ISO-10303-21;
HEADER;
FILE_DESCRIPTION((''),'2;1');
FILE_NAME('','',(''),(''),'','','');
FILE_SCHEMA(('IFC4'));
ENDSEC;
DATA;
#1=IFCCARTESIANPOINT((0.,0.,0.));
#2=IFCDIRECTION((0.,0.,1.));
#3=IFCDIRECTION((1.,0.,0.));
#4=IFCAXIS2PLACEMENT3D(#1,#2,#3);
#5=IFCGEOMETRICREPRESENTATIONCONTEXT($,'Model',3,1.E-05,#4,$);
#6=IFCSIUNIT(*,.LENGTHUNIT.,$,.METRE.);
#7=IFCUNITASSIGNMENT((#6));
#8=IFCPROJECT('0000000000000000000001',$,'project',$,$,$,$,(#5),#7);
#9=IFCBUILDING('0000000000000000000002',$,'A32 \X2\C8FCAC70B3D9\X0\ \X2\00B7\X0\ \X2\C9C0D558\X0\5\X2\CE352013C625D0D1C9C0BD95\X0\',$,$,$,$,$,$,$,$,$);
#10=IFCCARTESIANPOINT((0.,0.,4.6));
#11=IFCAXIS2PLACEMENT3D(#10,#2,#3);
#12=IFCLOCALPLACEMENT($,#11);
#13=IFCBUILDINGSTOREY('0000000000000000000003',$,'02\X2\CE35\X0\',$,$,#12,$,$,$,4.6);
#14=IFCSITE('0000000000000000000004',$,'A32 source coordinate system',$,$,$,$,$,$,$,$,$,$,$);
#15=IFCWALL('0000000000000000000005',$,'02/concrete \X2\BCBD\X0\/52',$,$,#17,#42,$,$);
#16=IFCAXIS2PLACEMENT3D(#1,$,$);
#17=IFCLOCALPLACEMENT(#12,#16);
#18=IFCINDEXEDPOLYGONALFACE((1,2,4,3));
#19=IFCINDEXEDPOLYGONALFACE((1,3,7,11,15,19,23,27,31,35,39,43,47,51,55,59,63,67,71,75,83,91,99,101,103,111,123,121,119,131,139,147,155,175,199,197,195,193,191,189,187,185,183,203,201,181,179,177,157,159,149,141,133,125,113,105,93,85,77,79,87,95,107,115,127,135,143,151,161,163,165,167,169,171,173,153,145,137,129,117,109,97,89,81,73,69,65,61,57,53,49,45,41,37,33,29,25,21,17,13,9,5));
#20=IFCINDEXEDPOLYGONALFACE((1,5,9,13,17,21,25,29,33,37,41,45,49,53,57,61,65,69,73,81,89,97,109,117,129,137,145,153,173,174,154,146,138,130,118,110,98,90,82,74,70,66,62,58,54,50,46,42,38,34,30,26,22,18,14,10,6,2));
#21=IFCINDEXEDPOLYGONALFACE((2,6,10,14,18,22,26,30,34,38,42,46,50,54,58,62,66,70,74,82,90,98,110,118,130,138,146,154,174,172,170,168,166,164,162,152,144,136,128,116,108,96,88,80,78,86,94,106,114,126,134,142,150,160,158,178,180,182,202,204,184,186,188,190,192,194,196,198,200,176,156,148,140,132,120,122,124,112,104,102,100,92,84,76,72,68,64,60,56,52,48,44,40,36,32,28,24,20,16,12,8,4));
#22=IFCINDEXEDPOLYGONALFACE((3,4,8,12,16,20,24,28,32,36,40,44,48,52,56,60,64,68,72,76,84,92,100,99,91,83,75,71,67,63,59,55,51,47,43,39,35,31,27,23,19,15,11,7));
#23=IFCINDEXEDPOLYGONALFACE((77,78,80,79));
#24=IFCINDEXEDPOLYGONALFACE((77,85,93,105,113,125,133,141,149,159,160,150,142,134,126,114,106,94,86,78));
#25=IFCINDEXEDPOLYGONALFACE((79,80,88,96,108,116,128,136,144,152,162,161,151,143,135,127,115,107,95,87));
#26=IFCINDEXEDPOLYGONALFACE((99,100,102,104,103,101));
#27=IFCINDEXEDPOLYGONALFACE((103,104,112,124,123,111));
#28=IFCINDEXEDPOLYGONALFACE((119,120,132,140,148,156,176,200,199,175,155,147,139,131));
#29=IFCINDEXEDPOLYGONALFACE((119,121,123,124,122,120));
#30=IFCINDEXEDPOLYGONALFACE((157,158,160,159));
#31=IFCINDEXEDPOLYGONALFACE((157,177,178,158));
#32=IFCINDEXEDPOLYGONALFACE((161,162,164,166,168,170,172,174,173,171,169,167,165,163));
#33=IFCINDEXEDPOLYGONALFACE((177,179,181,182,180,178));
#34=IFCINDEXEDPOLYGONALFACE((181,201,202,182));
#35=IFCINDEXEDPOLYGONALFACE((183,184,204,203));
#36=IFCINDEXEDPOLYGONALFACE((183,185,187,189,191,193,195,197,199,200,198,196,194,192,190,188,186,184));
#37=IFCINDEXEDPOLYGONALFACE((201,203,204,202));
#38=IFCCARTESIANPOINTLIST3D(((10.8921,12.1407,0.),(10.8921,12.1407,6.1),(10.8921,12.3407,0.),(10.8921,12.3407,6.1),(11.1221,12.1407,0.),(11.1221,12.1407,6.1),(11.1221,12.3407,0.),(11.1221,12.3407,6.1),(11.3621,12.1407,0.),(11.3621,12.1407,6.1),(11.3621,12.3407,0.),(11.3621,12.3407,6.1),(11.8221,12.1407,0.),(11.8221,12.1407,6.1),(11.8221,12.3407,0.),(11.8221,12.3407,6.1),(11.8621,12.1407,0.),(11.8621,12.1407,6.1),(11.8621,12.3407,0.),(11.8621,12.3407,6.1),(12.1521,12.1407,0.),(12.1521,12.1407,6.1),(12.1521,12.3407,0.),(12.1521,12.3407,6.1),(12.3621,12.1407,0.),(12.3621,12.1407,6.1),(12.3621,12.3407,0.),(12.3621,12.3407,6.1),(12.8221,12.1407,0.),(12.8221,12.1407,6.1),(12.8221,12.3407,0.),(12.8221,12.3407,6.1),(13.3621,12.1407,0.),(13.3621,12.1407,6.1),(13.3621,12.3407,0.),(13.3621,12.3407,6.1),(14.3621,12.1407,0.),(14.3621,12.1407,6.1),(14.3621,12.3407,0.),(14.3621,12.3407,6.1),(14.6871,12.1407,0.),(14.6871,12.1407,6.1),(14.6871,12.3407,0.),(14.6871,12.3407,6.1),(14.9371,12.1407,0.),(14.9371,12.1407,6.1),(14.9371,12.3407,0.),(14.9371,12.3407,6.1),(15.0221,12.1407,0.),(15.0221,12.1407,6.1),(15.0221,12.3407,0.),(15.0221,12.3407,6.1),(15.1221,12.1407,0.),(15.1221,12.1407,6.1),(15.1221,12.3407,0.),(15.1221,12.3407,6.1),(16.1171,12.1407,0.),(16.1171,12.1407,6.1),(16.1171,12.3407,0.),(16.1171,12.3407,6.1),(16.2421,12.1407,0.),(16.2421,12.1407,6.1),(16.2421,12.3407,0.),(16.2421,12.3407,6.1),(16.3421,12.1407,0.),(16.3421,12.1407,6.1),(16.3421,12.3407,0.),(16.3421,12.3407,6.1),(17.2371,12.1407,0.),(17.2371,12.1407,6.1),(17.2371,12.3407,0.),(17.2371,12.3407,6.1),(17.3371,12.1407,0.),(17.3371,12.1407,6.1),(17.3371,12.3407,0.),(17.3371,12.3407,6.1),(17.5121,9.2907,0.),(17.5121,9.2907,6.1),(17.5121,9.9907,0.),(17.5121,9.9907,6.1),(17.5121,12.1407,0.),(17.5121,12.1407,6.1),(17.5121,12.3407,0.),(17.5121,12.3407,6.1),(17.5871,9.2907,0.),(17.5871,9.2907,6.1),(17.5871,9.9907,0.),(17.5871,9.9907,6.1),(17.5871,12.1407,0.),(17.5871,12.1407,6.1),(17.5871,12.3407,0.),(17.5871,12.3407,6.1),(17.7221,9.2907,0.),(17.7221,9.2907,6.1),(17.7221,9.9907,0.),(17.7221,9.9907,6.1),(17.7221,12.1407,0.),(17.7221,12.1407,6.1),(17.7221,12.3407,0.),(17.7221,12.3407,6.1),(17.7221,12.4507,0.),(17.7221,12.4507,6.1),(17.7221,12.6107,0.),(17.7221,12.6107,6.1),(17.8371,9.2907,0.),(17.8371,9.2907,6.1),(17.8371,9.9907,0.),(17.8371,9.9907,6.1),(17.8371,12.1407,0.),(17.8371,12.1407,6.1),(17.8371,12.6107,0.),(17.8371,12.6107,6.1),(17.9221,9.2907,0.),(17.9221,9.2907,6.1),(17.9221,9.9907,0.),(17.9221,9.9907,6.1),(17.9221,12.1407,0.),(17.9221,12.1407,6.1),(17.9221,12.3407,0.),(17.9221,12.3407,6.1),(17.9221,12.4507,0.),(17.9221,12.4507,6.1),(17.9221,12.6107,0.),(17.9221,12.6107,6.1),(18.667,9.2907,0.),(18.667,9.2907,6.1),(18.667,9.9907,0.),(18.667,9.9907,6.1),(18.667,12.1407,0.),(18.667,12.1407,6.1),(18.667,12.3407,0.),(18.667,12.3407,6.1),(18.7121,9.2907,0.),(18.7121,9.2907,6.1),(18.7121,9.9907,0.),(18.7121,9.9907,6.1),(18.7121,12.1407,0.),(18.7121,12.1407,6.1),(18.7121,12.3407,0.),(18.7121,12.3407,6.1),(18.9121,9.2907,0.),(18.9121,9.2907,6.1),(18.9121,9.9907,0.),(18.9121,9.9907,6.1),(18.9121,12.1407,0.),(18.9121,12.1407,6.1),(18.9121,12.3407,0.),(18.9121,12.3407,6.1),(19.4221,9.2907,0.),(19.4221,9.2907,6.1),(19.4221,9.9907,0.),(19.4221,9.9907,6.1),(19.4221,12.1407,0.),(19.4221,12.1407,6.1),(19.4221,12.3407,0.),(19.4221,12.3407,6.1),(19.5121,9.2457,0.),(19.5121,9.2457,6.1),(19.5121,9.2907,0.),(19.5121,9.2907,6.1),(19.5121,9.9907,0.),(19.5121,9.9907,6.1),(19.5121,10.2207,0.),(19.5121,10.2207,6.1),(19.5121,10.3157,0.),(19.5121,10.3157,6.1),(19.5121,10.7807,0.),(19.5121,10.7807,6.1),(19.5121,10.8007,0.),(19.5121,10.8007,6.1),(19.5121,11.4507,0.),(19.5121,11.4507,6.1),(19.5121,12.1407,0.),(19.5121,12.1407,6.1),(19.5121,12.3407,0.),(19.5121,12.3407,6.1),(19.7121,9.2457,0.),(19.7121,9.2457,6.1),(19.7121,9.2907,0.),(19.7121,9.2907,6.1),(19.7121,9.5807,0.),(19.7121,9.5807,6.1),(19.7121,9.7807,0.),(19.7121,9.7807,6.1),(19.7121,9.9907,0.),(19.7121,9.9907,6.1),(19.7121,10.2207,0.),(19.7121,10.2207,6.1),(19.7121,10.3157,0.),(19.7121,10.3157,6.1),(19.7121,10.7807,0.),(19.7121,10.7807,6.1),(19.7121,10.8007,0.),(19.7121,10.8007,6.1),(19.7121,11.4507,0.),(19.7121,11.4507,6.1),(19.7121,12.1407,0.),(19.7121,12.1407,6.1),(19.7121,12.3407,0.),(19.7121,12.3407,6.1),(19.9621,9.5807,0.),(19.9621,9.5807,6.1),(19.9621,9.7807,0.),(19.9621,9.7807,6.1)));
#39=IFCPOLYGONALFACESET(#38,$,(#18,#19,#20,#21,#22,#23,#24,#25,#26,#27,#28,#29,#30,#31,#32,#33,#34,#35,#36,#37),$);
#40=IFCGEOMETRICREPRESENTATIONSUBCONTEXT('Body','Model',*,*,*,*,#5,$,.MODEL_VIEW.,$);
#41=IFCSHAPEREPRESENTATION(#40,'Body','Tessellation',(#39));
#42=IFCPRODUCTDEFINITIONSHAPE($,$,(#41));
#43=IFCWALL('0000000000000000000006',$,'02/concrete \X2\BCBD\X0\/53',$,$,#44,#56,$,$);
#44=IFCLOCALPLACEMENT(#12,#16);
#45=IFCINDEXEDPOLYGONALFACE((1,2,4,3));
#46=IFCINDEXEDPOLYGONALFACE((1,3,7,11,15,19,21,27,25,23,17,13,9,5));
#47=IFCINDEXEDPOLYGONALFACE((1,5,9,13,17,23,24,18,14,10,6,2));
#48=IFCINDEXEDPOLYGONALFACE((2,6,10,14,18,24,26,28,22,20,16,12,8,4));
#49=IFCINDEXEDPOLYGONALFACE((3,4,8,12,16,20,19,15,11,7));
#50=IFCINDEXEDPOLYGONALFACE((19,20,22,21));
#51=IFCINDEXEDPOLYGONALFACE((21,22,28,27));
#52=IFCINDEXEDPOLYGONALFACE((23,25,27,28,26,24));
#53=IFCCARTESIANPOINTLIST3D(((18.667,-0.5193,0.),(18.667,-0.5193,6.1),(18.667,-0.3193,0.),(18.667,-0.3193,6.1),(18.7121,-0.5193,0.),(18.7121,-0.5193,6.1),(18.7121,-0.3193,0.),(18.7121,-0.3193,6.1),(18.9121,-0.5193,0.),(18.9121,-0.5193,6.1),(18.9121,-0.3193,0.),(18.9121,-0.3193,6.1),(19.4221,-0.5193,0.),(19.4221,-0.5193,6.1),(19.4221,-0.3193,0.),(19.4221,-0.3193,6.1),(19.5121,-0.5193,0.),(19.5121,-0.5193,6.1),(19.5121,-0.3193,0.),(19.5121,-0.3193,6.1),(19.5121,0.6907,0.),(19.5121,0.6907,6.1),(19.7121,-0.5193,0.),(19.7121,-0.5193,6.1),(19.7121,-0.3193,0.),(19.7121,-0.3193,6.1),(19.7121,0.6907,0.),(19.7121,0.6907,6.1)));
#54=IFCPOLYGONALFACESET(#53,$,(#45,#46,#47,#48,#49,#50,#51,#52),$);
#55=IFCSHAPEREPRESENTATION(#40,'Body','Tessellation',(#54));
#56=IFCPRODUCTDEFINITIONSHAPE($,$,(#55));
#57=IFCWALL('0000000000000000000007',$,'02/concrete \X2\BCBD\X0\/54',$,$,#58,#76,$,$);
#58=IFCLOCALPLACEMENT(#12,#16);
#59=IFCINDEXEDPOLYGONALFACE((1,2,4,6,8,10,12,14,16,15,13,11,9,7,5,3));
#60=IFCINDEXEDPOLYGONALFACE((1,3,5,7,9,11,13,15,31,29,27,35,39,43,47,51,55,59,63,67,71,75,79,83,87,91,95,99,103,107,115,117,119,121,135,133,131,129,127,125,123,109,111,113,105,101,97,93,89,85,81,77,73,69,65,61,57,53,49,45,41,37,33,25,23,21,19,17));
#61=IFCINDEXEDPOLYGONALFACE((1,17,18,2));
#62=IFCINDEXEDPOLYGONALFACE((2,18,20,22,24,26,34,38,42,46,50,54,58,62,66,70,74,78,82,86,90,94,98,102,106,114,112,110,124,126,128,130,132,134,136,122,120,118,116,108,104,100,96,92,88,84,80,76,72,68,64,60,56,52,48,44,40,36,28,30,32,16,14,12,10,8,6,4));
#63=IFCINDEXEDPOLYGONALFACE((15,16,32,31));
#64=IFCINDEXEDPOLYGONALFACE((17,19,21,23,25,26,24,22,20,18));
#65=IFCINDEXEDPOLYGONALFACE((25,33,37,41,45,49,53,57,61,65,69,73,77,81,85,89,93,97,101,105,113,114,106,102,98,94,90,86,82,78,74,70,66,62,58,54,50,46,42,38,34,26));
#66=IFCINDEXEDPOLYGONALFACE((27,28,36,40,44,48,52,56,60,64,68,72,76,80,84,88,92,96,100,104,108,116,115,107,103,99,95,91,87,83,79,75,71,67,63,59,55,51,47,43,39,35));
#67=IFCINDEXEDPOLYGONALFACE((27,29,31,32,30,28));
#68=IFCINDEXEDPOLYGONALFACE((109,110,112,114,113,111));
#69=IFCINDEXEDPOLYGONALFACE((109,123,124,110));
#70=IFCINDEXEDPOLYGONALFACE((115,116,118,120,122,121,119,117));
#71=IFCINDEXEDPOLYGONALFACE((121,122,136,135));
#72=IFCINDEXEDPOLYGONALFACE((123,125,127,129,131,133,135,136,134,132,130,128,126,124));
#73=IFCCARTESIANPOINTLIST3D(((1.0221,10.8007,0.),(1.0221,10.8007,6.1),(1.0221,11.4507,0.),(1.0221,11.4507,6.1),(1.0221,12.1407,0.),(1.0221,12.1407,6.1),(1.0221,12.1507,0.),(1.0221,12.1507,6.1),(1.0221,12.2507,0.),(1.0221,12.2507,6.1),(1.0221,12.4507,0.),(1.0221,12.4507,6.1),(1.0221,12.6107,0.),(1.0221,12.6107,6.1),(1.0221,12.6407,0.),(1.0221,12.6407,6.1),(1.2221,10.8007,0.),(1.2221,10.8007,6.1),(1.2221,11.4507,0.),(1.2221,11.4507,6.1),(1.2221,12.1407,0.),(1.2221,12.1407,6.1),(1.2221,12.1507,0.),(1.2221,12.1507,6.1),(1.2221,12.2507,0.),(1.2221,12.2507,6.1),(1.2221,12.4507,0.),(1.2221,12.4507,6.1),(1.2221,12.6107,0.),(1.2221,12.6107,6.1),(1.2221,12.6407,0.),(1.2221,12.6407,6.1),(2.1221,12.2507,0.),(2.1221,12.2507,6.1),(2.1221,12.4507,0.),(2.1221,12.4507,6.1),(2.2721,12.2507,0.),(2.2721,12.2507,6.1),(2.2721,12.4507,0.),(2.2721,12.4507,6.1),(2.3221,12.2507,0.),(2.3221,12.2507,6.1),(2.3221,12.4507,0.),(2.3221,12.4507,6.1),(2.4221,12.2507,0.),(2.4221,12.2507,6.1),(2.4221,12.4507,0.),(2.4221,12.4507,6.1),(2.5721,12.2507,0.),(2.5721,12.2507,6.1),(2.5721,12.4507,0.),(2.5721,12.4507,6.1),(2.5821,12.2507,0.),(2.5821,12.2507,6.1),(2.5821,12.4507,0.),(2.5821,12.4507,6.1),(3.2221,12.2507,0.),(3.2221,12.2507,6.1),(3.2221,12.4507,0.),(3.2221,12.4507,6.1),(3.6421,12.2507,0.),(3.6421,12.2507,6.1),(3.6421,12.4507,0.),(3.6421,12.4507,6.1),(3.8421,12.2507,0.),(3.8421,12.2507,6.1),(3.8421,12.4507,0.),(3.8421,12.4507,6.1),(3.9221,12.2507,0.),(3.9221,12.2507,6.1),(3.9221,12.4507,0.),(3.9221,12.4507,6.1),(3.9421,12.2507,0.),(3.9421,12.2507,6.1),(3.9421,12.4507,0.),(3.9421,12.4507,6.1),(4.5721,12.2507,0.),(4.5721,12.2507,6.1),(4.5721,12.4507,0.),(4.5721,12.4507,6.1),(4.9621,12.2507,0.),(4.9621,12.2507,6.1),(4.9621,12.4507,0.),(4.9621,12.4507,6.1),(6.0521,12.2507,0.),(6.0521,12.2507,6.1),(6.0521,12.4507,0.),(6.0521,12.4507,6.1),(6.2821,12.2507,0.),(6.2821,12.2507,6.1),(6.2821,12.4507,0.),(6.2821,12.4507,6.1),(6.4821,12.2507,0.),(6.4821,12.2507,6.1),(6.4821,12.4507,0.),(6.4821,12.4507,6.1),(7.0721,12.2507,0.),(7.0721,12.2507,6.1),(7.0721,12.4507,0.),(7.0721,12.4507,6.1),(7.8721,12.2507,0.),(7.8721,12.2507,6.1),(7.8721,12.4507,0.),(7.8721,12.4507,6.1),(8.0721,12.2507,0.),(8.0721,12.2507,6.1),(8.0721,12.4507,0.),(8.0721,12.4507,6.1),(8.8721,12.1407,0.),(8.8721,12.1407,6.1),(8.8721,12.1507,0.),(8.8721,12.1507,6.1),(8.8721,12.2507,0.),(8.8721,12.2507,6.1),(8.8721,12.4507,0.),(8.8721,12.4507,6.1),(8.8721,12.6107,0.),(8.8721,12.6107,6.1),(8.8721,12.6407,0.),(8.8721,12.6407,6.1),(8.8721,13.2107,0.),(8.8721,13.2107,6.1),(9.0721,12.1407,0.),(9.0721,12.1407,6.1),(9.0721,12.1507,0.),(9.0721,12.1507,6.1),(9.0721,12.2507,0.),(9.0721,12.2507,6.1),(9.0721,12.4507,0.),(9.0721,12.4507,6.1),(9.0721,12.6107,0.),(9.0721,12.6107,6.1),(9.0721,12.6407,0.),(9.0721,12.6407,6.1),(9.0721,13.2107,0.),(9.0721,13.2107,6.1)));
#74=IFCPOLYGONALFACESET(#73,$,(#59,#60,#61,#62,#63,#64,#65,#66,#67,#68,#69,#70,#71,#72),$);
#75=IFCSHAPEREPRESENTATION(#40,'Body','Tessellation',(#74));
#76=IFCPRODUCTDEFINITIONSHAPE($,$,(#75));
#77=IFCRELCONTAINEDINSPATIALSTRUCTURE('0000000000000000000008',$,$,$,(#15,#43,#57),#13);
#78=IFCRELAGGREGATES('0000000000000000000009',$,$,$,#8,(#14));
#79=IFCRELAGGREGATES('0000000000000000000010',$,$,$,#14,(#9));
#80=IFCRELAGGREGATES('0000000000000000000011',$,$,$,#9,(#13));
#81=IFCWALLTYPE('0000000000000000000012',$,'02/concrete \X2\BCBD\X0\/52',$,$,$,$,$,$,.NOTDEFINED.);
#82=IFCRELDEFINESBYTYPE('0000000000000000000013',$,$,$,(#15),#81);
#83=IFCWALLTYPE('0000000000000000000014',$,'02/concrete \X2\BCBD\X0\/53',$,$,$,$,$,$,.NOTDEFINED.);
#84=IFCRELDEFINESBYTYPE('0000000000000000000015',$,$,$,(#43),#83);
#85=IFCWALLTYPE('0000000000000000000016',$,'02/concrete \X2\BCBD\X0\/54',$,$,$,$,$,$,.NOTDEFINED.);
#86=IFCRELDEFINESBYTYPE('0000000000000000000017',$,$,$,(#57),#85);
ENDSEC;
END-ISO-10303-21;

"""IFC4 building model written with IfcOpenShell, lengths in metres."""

from ifc_helpers import new_model, si_unit, frame, origin, origin_with_axes, place, context, subcontext, project, spatial, polyline, outline, extrude, source, transform, mapped, type_object, type_shapes, element, save


model = new_model("IFC4")

# Units and contexts
model_context = context("Model", 3, precision=1e-05, world=origin_with_axes())
body_context = subcontext(model_context, "Body", "Model", "MODEL_VIEW")
ifc_project = project(units=[si_unit("LENGTHUNIT", "METRE")], contexts=[model_context])

# Site, building, storey
site = spatial("IfcSite", under=ifc_project, Name="A32 source coordinate system")
building = spatial("IfcBuilding", under=site, Name="A32 주거동 · 지하5층–옥탑지붕")
storey_placement = place(None, frame((0.0, 0.0, 4.6), z_axis=(0.0, 0.0, 1.0), x_axis=(1.0, 0.0, 0.0)))
storey = spatial("IfcBuildingStorey", under=building, at=storey_placement, Name="02층", Elevation=4.6)

# Walls
wall_type_1 = type_object("IfcWallType", Name="02/concrete 벽/52", PredefinedType="NOTDEFINED")
shared_shape_1 = source(origin(), body_context, "Body", "SweptSolid", [
    extrude(outline(polyline([(12.8221, 12.3407), (13.3621, 12.3407), (14.3621, 12.3407), (14.6871, 12.3407), (14.9371, 12.3407), (15.0221, 12.3407), (15.1221, 12.3407), (16.1171, 12.3407), (16.2421, 12.3407), (16.3421, 12.3407), (17.2371, 12.3407), (17.3371, 12.3407), (17.5121, 12.3407), (17.5871, 12.3407), (17.7221, 12.3407), (17.7221, 12.4507), (17.7221, 12.6107), (17.8371, 12.6107), (17.9221, 12.6107), (17.9221, 12.4507), (17.9221, 12.3407), (18.667, 12.3407), (18.7121, 12.3407), (18.9121, 12.3407), (19.4221, 12.3407), (19.5121, 12.3407), (19.7121, 12.3407), (19.7121, 12.1407), (19.7121, 11.4507), (19.7121, 10.8007), (19.7121, 10.7807), (19.7121, 10.3157), (19.7121, 10.2207), (19.7121, 9.9907), (19.7121, 9.7807), (19.9621, 9.7807), (19.9621, 9.5807), (19.7121, 9.5807), (19.7121, 9.2907), (19.7121, 9.2457), (19.5121, 9.2457), (19.5121, 9.2907), (19.4221, 9.2907), (18.9121, 9.2907), (18.7121, 9.2907), (18.667, 9.2907), (17.9221, 9.2907), (17.8371, 9.2907), (17.7221, 9.2907), (17.5871, 9.2907), (17.5121, 9.2907), (17.5121, 9.9907), (17.5871, 9.9907), (17.7221, 9.9907), (17.8371, 9.9907), (17.9221, 9.9907), (18.667, 9.9907), (18.7121, 9.9907), (18.9121, 9.9907), (19.4221, 9.9907), (19.5121, 9.9907), (19.5121, 10.2207), (19.5121, 10.3157), (19.5121, 10.7807), (19.5121, 10.8007), (19.5121, 11.4507), (19.5121, 12.1407), (19.4221, 12.1407), (18.9121, 12.1407), (18.7121, 12.1407), (18.667, 12.1407), (17.9221, 12.1407), (17.8371, 12.1407), (17.7221, 12.1407), (17.5871, 12.1407), (17.5121, 12.1407), (17.3371, 12.1407), (17.2371, 12.1407), (16.3421, 12.1407), (16.2421, 12.1407), (16.1171, 12.1407), (15.1221, 12.1407), (15.0221, 12.1407), (14.9371, 12.1407), (14.6871, 12.1407), (14.3621, 12.1407), (13.3621, 12.1407), (12.8221, 12.1407), (12.3621, 12.1407), (12.1521, 12.1407), (11.8621, 12.1407), (11.8221, 12.1407), (11.3621, 12.1407), (11.1221, 12.1407), (10.8921, 12.1407), (10.8921, 12.3407), (11.1221, 12.3407), (11.3621, 12.3407), (11.8221, 12.3407), (11.8621, 12.3407), (12.1521, 12.3407), (12.3621, 12.3407), (12.8221, 12.3407)])), origin(), (0.0, 0.0, 1.0), 6.1),
])
type_shapes(wall_type_1, [shared_shape_1])
wall_1_placement = place(storey_placement, origin_with_axes())
element("IfcWall", 1, at=wall_1_placement, inside=storey, type_object=wall_type_1, Name="02/concrete 벽/52", context=body_context, shape_type="MappedRepresentation", body=[
    mapped(shared_shape_1, transform((0.0, 0.0, 0.0), scale=1.0)),
])
wall_type_2 = type_object("IfcWallType", Name="02/concrete 벽/53", PredefinedType="NOTDEFINED")
shared_shape_2 = source(origin(), body_context, "Body", "SweptSolid", [
    extrude(outline(polyline([(18.7121, -0.3193), (18.9121, -0.3193), (19.4221, -0.3193), (19.5121, -0.3193), (19.5121, 0.6907), (19.7121, 0.6907), (19.7121, -0.3193), (19.7121, -0.5193), (19.5121, -0.5193), (19.4221, -0.5193), (18.9121, -0.5193), (18.7121, -0.5193), (18.667, -0.5193), (18.667, -0.3193), (18.7121, -0.3193)])), origin(), (0.0, 0.0, 1.0), 6.1),
])
type_shapes(wall_type_2, [shared_shape_2])
wall_2_placement = place(storey_placement, origin_with_axes())
element("IfcWall", 2, at=wall_2_placement, inside=storey, type_object=wall_type_2, Name="02/concrete 벽/53", context=body_context, shape_type="MappedRepresentation", body=[
    mapped(shared_shape_2, transform((0.0, 0.0, 0.0), scale=1.0)),
])
wall_type_3 = type_object("IfcWallType", Name="02/concrete 벽/54", PredefinedType="NOTDEFINED")
shared_shape_3 = source(origin(), body_context, "Body", "SweptSolid", [
    extrude(outline(polyline([(1.0221, 11.4507), (1.0221, 12.1407), (1.0221, 12.1507), (1.0221, 12.2507), (1.0221, 12.4507), (1.0221, 12.6107), (1.0221, 12.6407), (1.2221, 12.6407), (1.2221, 12.6107), (1.2221, 12.4507), (2.1221, 12.4507), (2.2721, 12.4507), (2.3221, 12.4507), (2.4221, 12.4507), (2.5721, 12.4507), (2.5821, 12.4507), (3.2221, 12.4507), (3.6421, 12.4507), (3.8421, 12.4507), (3.9221, 12.4507), (3.9421, 12.4507), (4.5721, 12.4507), (4.9621, 12.4507), (6.0521, 12.4507), (6.2821, 12.4507), (6.4821, 12.4507), (7.0721, 12.4507), (7.8721, 12.4507), (8.0721, 12.4507), (8.8721, 12.4507), (8.8721, 12.6107), (8.8721, 12.6407), (8.8721, 13.2107), (9.0721, 13.2107), (9.0721, 12.6407), (9.0721, 12.6107), (9.0721, 12.4507), (9.0721, 12.2507), (9.0721, 12.1507), (9.0721, 12.1407), (8.8721, 12.1407), (8.8721, 12.1507), (8.8721, 12.2507), (8.0721, 12.2507), (7.8721, 12.2507), (7.0721, 12.2507), (6.4821, 12.2507), (6.2821, 12.2507), (6.0521, 12.2507), (4.9621, 12.2507), (4.5721, 12.2507), (3.9421, 12.2507), (3.9221, 12.2507), (3.8421, 12.2507), (3.6421, 12.2507), (3.2221, 12.2507), (2.5821, 12.2507), (2.5721, 12.2507), (2.4221, 12.2507), (2.3221, 12.2507), (2.2721, 12.2507), (2.1221, 12.2507), (1.2221, 12.2507), (1.2221, 12.1507), (1.2221, 12.1407), (1.2221, 11.4507), (1.2221, 10.8007), (1.0221, 10.8007), (1.0221, 11.4507)])), origin(), (0.0, 0.0, 1.0), 6.1),
])
type_shapes(wall_type_3, [shared_shape_3])
wall_3_placement = place(storey_placement, origin_with_axes())
element("IfcWall", 3, at=wall_3_placement, inside=storey, type_object=wall_type_3, Name="02/concrete 벽/54", context=body_context, shape_type="MappedRepresentation", body=[
    mapped(shared_shape_3, transform((0.0, 0.0, 0.0), scale=1.0)),
])

save(model, "model.ifc")
